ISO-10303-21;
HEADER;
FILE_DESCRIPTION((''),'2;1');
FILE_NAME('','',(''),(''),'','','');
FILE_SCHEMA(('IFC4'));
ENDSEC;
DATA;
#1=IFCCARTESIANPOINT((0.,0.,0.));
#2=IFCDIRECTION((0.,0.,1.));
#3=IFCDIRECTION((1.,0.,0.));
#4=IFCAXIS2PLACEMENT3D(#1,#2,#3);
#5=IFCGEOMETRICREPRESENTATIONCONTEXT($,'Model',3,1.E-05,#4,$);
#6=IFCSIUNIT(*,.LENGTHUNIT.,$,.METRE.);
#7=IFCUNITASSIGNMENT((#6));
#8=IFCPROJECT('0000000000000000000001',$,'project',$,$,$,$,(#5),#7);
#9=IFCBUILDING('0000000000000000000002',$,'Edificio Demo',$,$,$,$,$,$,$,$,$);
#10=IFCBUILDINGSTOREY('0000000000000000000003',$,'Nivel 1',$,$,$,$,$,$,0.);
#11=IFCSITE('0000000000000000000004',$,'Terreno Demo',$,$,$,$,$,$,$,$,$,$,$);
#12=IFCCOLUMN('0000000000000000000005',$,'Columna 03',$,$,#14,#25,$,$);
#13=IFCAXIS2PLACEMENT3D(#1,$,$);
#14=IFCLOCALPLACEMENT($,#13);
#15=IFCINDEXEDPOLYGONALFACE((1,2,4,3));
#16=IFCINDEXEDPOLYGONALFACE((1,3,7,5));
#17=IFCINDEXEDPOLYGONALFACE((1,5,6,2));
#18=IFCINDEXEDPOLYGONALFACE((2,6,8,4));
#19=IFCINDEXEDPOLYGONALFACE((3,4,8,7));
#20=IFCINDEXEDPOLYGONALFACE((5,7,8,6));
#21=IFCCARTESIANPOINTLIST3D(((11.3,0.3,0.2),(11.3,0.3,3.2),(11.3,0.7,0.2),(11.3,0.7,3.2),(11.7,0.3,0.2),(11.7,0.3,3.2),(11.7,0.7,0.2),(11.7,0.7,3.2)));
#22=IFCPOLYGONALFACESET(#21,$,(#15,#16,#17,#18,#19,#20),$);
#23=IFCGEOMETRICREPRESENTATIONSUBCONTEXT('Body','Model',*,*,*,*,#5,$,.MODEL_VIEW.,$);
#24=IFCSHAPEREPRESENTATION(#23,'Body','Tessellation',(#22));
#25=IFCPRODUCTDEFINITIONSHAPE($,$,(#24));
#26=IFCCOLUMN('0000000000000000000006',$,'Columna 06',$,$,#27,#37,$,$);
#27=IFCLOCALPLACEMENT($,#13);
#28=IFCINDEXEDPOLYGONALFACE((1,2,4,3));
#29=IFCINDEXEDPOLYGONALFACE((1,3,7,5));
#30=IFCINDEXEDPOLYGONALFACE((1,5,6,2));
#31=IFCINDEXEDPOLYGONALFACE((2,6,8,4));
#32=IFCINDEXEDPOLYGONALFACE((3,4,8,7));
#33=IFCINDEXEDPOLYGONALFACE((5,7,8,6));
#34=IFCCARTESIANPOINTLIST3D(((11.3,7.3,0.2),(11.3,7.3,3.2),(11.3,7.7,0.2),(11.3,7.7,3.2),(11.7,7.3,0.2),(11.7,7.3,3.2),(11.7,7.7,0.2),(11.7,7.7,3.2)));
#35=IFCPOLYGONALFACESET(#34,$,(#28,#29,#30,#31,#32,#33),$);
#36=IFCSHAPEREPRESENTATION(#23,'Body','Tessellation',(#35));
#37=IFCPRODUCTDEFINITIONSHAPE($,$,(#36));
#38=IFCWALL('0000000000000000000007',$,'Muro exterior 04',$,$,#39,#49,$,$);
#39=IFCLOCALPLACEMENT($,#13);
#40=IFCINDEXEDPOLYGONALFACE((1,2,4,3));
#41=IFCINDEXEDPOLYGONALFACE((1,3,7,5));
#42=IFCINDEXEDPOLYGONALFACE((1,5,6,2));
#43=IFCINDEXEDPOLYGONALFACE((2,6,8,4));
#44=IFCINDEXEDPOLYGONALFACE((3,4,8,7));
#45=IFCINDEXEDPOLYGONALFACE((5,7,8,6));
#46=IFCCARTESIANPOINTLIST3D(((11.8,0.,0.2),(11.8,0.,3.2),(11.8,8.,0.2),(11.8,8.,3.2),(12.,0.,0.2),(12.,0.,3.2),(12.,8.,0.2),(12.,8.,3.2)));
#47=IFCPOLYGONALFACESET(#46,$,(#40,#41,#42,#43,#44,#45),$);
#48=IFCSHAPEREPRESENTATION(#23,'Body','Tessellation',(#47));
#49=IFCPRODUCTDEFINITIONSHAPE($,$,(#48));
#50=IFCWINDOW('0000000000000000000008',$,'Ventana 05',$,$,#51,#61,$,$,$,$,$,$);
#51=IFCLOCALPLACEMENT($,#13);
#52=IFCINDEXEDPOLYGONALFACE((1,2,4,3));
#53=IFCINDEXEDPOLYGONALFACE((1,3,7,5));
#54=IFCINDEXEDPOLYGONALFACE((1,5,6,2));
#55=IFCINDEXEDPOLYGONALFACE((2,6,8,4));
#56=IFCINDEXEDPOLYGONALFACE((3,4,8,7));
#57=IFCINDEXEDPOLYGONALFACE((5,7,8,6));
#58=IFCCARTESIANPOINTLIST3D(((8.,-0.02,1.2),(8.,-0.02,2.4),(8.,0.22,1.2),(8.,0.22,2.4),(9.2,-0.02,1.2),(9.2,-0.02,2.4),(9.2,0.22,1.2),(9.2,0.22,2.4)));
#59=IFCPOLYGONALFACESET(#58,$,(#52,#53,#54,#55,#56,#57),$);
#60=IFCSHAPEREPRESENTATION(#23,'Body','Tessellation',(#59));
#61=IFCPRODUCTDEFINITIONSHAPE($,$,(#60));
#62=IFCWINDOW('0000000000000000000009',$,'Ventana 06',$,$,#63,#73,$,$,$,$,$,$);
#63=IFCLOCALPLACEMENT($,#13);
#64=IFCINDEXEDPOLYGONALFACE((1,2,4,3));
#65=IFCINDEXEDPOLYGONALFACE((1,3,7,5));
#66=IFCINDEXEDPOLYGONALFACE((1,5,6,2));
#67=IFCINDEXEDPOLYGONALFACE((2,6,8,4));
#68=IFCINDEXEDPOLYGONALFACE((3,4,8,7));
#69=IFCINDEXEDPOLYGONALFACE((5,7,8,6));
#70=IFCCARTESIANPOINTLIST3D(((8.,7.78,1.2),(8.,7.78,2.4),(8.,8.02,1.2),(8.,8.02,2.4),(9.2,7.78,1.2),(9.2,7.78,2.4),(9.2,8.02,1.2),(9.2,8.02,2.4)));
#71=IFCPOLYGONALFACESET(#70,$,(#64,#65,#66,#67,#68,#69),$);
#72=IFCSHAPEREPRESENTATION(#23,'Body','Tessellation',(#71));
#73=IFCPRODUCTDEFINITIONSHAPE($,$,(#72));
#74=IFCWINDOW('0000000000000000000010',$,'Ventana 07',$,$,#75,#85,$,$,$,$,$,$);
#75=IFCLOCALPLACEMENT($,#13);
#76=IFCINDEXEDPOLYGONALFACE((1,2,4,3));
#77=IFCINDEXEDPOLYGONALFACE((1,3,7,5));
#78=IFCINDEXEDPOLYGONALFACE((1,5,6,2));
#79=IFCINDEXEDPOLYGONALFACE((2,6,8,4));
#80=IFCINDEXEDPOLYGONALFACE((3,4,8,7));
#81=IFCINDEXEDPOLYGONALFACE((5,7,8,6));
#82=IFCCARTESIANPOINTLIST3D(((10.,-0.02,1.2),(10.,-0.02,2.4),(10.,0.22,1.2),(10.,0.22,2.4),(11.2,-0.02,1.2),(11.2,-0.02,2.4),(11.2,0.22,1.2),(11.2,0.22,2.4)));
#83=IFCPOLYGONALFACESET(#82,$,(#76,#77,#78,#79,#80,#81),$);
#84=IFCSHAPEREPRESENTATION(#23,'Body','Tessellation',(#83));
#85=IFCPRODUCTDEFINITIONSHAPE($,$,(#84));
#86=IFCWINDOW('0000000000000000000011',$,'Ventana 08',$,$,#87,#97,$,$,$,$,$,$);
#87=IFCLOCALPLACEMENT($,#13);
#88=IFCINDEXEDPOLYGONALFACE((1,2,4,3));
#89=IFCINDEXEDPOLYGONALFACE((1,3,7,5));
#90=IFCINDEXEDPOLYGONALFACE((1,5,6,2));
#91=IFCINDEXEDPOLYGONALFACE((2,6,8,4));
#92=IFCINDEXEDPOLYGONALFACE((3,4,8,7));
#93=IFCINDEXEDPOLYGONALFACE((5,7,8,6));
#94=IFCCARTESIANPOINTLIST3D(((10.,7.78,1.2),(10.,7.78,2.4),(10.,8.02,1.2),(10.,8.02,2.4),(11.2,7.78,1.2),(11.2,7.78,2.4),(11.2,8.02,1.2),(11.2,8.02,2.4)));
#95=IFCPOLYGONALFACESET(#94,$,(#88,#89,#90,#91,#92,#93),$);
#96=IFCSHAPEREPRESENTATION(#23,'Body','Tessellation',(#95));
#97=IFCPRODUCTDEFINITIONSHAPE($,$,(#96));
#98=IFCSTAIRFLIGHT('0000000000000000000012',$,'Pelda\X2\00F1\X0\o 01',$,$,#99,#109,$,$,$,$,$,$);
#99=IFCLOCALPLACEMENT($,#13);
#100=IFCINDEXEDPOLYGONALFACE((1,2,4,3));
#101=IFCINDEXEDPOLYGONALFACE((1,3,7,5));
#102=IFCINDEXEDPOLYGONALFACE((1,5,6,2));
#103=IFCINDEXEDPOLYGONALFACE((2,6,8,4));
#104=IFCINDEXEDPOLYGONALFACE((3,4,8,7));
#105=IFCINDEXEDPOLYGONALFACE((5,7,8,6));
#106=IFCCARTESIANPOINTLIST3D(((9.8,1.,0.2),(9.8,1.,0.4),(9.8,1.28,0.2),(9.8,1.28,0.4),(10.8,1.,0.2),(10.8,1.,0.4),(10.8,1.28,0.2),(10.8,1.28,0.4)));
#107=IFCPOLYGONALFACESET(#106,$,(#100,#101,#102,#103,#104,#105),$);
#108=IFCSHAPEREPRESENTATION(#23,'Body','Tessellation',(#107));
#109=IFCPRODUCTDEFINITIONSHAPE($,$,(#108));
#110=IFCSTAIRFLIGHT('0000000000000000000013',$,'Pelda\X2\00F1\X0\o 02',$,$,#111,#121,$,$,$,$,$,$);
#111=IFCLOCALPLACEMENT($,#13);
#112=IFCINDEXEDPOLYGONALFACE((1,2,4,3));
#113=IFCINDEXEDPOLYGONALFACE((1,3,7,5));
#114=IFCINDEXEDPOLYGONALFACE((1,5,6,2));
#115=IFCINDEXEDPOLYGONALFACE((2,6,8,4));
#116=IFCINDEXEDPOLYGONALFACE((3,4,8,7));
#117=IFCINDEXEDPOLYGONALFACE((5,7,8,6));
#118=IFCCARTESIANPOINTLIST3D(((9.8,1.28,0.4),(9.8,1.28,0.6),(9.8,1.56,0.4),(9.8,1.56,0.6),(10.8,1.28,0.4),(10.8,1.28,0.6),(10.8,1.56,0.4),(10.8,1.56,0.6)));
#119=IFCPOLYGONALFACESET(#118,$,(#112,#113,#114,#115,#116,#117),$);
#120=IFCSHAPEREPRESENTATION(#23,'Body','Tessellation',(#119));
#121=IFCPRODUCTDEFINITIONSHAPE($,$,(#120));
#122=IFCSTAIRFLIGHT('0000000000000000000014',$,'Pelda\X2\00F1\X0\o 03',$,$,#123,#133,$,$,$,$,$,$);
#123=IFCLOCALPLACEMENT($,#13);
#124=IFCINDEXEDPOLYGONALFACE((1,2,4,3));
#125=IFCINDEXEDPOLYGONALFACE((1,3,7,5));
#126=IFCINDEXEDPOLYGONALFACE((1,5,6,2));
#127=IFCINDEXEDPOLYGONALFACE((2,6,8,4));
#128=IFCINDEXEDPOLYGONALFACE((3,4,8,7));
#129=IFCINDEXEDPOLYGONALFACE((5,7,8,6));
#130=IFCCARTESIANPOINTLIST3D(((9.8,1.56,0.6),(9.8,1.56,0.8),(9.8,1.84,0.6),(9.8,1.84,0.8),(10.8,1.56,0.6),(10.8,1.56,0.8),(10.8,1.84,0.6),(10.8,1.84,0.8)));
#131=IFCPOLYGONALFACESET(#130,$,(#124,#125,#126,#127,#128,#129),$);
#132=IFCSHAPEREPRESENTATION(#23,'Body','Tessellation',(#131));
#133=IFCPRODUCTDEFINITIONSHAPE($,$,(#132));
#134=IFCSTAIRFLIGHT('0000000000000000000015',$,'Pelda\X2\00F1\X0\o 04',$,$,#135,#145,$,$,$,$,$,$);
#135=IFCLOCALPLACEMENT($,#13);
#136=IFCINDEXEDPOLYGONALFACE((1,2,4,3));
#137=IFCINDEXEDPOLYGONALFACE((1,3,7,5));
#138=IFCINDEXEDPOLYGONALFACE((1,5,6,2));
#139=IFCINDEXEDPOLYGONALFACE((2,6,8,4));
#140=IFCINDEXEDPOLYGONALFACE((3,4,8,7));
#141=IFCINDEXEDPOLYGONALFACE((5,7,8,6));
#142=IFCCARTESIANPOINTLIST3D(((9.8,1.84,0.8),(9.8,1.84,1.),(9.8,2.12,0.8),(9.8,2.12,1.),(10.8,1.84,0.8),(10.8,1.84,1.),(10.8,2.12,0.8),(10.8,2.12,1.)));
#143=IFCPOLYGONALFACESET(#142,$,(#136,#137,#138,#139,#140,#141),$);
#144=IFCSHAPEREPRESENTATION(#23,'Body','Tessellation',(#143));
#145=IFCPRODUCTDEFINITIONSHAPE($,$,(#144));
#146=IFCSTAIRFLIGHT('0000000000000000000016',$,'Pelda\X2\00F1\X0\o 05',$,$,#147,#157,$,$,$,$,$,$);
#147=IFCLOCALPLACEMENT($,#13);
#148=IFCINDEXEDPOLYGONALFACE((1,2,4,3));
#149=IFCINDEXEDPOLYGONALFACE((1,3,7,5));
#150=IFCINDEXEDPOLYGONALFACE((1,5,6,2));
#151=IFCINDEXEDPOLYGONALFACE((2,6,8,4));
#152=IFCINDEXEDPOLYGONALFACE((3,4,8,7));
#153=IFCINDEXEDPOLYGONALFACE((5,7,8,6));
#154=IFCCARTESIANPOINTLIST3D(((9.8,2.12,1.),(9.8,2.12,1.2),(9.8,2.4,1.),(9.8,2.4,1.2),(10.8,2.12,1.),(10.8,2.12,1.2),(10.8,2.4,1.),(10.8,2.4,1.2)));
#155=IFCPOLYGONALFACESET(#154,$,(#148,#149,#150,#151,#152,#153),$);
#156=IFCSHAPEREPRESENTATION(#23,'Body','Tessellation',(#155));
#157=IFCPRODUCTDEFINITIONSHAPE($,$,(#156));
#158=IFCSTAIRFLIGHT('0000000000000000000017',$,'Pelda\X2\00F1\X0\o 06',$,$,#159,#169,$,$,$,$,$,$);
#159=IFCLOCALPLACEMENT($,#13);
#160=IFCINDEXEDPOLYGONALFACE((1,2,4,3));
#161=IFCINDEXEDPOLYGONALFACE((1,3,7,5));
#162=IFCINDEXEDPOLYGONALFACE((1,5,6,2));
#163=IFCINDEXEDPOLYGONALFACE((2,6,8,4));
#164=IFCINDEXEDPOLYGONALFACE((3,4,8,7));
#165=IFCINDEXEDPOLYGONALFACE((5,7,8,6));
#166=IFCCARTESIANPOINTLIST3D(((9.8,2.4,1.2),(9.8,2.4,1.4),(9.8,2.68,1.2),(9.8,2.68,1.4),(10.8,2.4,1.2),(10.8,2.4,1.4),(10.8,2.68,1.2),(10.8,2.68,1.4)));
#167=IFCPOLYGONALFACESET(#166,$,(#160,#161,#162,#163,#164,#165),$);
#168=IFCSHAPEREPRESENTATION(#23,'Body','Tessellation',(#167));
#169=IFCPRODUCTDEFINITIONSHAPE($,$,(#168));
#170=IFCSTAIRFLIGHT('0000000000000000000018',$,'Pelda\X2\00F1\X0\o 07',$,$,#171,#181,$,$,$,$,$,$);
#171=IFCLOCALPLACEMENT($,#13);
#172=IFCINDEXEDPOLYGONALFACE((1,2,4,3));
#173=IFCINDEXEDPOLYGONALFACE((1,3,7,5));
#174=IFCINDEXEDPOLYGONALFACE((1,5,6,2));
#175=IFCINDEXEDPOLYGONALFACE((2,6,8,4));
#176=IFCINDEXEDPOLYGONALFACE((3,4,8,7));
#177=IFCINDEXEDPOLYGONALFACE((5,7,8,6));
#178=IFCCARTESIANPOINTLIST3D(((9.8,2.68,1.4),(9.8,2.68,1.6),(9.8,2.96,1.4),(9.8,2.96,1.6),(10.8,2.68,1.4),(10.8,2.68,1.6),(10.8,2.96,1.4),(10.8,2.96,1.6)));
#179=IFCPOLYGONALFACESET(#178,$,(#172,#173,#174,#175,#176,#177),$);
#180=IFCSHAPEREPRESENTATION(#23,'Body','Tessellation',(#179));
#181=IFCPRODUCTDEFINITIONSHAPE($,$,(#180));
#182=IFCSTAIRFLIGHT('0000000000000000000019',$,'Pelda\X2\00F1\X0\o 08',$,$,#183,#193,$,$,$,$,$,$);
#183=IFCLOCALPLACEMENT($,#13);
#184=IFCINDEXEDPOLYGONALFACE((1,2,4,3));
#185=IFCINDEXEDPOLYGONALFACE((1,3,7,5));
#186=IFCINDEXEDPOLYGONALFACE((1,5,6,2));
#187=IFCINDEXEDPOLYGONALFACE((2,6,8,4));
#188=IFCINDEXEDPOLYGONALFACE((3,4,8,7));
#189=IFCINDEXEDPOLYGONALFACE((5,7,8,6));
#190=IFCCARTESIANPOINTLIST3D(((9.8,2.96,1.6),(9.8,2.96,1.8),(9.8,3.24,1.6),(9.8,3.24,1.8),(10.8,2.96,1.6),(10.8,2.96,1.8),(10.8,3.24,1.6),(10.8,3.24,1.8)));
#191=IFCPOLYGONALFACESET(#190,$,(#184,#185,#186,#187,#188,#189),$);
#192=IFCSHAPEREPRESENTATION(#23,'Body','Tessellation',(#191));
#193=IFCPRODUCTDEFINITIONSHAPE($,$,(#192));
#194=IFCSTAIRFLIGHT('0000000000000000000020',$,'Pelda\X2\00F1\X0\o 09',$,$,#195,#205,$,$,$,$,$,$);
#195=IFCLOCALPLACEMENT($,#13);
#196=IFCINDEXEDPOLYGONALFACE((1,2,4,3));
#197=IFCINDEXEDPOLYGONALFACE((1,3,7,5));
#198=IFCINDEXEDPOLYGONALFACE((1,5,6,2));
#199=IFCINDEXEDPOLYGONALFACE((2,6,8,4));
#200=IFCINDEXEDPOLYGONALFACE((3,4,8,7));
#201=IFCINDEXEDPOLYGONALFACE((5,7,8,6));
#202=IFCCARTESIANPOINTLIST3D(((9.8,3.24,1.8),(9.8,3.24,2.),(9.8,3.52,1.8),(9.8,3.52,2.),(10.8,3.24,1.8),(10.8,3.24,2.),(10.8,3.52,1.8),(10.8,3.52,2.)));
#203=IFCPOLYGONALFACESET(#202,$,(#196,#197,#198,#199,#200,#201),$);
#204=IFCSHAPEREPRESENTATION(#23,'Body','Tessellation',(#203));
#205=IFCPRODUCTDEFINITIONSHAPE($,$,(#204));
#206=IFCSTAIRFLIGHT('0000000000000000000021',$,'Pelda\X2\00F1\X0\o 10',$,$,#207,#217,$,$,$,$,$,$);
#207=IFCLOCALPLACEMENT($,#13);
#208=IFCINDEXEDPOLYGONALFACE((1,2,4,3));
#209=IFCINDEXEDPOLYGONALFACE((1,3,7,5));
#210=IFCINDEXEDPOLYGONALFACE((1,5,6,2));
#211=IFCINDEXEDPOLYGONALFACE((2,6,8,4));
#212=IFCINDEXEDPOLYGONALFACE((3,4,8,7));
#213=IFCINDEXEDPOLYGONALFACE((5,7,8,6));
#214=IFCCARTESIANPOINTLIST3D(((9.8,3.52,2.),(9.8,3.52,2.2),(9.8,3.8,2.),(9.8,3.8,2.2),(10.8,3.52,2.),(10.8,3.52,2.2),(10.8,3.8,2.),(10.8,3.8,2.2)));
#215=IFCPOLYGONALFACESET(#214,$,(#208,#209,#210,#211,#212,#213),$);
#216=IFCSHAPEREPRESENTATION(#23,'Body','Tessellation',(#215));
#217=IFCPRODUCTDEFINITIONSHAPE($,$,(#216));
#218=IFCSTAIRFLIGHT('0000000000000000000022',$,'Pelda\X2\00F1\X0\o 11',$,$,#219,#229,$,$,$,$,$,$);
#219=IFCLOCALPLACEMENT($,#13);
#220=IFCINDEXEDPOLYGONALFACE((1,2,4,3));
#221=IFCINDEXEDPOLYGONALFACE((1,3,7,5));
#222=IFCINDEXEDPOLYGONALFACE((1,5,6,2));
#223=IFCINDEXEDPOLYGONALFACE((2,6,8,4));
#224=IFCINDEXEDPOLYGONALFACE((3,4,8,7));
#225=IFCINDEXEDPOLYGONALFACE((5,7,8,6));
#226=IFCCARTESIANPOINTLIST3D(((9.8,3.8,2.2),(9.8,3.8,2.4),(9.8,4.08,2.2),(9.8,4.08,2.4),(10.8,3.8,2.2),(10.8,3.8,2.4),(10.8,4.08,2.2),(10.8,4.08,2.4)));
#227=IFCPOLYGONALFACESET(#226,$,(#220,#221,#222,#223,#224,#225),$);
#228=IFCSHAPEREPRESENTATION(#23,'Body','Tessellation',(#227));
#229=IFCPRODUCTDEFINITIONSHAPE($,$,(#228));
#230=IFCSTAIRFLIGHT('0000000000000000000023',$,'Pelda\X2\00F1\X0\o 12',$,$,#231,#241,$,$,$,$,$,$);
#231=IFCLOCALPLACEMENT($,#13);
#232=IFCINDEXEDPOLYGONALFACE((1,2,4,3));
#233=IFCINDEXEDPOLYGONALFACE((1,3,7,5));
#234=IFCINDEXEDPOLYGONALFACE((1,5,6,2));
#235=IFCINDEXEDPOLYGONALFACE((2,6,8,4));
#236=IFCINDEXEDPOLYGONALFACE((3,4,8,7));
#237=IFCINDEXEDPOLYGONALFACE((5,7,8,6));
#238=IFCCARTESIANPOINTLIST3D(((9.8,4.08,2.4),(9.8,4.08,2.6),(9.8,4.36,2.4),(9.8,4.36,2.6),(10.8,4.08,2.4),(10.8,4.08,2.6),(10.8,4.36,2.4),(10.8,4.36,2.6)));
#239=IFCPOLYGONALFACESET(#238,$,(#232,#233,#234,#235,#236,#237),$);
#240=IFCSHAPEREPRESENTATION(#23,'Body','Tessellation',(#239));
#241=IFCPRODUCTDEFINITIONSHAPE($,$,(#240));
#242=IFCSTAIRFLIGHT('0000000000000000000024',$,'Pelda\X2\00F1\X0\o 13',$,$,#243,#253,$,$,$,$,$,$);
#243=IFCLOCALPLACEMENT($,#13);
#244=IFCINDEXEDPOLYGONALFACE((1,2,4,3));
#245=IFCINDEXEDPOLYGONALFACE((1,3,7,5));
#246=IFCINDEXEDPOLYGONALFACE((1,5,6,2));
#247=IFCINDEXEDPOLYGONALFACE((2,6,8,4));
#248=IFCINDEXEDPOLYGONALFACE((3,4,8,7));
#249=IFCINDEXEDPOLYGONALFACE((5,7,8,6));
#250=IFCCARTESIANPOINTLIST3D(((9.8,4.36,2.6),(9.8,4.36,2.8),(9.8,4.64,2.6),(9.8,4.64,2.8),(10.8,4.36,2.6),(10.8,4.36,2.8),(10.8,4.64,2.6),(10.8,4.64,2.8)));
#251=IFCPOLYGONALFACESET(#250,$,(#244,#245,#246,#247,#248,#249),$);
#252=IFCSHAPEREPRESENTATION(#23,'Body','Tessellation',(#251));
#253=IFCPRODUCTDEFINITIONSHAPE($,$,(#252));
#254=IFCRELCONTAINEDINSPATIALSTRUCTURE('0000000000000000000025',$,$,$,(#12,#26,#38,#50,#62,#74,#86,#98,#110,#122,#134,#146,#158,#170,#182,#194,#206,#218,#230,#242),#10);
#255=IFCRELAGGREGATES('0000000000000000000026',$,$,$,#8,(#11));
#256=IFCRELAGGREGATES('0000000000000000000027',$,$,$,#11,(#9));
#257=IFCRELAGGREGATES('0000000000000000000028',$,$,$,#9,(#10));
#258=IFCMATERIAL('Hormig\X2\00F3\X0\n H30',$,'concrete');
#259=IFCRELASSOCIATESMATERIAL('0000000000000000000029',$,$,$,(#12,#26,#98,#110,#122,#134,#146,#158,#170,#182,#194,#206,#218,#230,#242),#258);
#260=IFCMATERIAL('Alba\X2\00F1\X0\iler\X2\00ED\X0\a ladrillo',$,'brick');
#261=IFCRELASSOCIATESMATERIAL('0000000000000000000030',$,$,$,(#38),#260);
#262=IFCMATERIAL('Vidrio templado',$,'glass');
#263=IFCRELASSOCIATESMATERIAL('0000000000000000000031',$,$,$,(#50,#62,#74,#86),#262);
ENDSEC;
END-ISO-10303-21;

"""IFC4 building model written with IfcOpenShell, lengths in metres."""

from ifc_helpers import new_model, si_unit, frame, frame_2d, origin_with_axes, place, context, subcontext, project, spatial, rectangle, extrude, material, element, save


model = new_model("IFC4")

# Units and contexts
model_context = context("Model", 3, precision=1e-05, world=origin_with_axes())
body_context = subcontext(model_context, "Body", "Model", "MODEL_VIEW")
ifc_project = project(units=[si_unit("LENGTHUNIT", "METRE")], contexts=[model_context])

# Site, building, storey
site = spatial("IfcSite", under=ifc_project, Name="Terreno Demo")
building = spatial("IfcBuilding", under=site, Name="Edificio Demo")
storey = spatial("IfcBuildingStorey", under=building, Name="Nivel 1", Elevation=0.0)

# Columns
ifc_material_1 = material(Name="Hormigón H30", Category="concrete")
for number, where, z_axis, x_axis, name in (
    (1, (11.3, 0.3, 0.2), (0.0, 0.0, 1.0), (1.0, 0.0, 0.0), "Columna 03"),
    (2, (11.3, 7.3, 0.2), (0.0, 0.0, 1.0), (1.0, 0.0, 0.0), "Columna 06"),
):
    element("IfcColumn", number, at=place(None, frame(where, z_axis=z_axis, x_axis=x_axis)), inside=storey, material=ifc_material_1, Name=name, context=body_context, shape_type="SweptSolid", body=[
        extrude(rectangle(XDim=0.4, YDim=0.4, at=frame_2d((0.2, 0.2))), origin_with_axes(), (0.0, 0.0, 1.0), 3.0),
    ])

# Wall
ifc_material_2 = material(Name="Albañilería ladrillo", Category="brick")
wall_placement = place(None, frame((11.8, 0.0, 0.2), z_axis=(0.0, 0.0, 1.0), x_axis=(1.0, 0.0, 0.0)))
element("IfcWall", 3, at=wall_placement, inside=storey, material=ifc_material_2, Name="Muro exterior 04", context=body_context, shape_type="SweptSolid", body=[
    extrude(rectangle(XDim=0.2, YDim=8.0, at=frame_2d((0.1, 4.0))), origin_with_axes(), (0.0, 0.0, 1.0), 3.0),
])

# Windows
ifc_material_3 = material(Name="Vidrio templado", Category="glass")
for number, where, z_axis, x_axis, name in (
    (4, (8.0, -0.02, 1.2), (0.0, 0.0, 1.0), (1.0, 0.0, 0.0), "Ventana 05"),
    (5, (8.0, 7.78, 1.2), (0.0, 0.0, 1.0), (1.0, 0.0, 0.0), "Ventana 06"),
    (6, (10.0, -0.02, 1.2), (0.0, 0.0, 1.0), (1.0, 0.0, 0.0), "Ventana 07"),
    (7, (10.0, 7.78, 1.2), (0.0, 0.0, 1.0), (1.0, 0.0, 0.0), "Ventana 08"),
):
    element("IfcWindow", number, at=place(None, frame(where, z_axis=z_axis, x_axis=x_axis)), inside=storey, material=ifc_material_3, Name=name, context=body_context, shape_type="SweptSolid", body=[
        extrude(rectangle(XDim=1.2, YDim=0.24, at=frame_2d((0.6, 0.12))), origin_with_axes(), (0.0, 0.0, 1.0), 1.2),
    ])

# Stair flights
for number, where, z_axis, x_axis, name in (
    (8, (9.8, 1.0, 0.2), (0.0, 0.0, 1.0), (1.0, 0.0, 0.0), "Peldaño 01"),
    (9, (9.8, 1.28, 0.4), (0.0, 0.0, 1.0), (1.0, 0.0, 0.0), "Peldaño 02"),
    (10, (9.8, 1.56, 0.6), (0.0, 0.0, 1.0), (1.0, 0.0, 0.0), "Peldaño 03"),
    (11, (9.8, 1.84, 0.8), (0.0, 0.0, 1.0), (1.0, 0.0, 0.0), "Peldaño 04"),
    (12, (9.8, 2.12, 1.0), (0.0, 0.0, 1.0), (1.0, 0.0, 0.0), "Peldaño 05"),
    (13, (9.8, 2.4, 1.2), (0.0, 0.0, 1.0), (1.0, 0.0, 0.0), "Peldaño 06"),
    (14, (9.8, 2.68, 1.4), (0.0, 0.0, 1.0), (1.0, 0.0, 0.0), "Peldaño 07"),
    (15, (9.8, 2.96, 1.6), (0.0, 0.0, 1.0), (1.0, 0.0, 0.0), "Peldaño 08"),
    (16, (9.8, 3.24, 1.8), (0.0, 0.0, 1.0), (1.0, 0.0, 0.0), "Peldaño 09"),
    (17, (9.8, 3.52, 2.0), (0.0, 0.0, 1.0), (1.0, 0.0, 0.0), "Peldaño 10"),
    (18, (9.8, 3.8, 2.2), (0.0, 0.0, 1.0), (1.0, 0.0, 0.0), "Peldaño 11"),
    (19, (9.8, 4.08, 2.4), (0.0, 0.0, 1.0), (1.0, 0.0, 0.0), "Peldaño 12"),
    (20, (9.8, 4.36, 2.6), (0.0, 0.0, 1.0), (1.0, 0.0, 0.0), "Peldaño 13"),
):
    element("IfcStairFlight", number, at=place(None, frame(where, z_axis=z_axis, x_axis=x_axis)), inside=storey, material=ifc_material_1, Name=name, context=body_context, shape_type="SweptSolid", body=[
        extrude(rectangle(XDim=1.0, YDim=0.28, at=frame_2d((0.5, 0.14))), origin_with_axes(), (0.0, 0.0, 1.0), 0.2),
    ])

save(model, "model.ifc")
